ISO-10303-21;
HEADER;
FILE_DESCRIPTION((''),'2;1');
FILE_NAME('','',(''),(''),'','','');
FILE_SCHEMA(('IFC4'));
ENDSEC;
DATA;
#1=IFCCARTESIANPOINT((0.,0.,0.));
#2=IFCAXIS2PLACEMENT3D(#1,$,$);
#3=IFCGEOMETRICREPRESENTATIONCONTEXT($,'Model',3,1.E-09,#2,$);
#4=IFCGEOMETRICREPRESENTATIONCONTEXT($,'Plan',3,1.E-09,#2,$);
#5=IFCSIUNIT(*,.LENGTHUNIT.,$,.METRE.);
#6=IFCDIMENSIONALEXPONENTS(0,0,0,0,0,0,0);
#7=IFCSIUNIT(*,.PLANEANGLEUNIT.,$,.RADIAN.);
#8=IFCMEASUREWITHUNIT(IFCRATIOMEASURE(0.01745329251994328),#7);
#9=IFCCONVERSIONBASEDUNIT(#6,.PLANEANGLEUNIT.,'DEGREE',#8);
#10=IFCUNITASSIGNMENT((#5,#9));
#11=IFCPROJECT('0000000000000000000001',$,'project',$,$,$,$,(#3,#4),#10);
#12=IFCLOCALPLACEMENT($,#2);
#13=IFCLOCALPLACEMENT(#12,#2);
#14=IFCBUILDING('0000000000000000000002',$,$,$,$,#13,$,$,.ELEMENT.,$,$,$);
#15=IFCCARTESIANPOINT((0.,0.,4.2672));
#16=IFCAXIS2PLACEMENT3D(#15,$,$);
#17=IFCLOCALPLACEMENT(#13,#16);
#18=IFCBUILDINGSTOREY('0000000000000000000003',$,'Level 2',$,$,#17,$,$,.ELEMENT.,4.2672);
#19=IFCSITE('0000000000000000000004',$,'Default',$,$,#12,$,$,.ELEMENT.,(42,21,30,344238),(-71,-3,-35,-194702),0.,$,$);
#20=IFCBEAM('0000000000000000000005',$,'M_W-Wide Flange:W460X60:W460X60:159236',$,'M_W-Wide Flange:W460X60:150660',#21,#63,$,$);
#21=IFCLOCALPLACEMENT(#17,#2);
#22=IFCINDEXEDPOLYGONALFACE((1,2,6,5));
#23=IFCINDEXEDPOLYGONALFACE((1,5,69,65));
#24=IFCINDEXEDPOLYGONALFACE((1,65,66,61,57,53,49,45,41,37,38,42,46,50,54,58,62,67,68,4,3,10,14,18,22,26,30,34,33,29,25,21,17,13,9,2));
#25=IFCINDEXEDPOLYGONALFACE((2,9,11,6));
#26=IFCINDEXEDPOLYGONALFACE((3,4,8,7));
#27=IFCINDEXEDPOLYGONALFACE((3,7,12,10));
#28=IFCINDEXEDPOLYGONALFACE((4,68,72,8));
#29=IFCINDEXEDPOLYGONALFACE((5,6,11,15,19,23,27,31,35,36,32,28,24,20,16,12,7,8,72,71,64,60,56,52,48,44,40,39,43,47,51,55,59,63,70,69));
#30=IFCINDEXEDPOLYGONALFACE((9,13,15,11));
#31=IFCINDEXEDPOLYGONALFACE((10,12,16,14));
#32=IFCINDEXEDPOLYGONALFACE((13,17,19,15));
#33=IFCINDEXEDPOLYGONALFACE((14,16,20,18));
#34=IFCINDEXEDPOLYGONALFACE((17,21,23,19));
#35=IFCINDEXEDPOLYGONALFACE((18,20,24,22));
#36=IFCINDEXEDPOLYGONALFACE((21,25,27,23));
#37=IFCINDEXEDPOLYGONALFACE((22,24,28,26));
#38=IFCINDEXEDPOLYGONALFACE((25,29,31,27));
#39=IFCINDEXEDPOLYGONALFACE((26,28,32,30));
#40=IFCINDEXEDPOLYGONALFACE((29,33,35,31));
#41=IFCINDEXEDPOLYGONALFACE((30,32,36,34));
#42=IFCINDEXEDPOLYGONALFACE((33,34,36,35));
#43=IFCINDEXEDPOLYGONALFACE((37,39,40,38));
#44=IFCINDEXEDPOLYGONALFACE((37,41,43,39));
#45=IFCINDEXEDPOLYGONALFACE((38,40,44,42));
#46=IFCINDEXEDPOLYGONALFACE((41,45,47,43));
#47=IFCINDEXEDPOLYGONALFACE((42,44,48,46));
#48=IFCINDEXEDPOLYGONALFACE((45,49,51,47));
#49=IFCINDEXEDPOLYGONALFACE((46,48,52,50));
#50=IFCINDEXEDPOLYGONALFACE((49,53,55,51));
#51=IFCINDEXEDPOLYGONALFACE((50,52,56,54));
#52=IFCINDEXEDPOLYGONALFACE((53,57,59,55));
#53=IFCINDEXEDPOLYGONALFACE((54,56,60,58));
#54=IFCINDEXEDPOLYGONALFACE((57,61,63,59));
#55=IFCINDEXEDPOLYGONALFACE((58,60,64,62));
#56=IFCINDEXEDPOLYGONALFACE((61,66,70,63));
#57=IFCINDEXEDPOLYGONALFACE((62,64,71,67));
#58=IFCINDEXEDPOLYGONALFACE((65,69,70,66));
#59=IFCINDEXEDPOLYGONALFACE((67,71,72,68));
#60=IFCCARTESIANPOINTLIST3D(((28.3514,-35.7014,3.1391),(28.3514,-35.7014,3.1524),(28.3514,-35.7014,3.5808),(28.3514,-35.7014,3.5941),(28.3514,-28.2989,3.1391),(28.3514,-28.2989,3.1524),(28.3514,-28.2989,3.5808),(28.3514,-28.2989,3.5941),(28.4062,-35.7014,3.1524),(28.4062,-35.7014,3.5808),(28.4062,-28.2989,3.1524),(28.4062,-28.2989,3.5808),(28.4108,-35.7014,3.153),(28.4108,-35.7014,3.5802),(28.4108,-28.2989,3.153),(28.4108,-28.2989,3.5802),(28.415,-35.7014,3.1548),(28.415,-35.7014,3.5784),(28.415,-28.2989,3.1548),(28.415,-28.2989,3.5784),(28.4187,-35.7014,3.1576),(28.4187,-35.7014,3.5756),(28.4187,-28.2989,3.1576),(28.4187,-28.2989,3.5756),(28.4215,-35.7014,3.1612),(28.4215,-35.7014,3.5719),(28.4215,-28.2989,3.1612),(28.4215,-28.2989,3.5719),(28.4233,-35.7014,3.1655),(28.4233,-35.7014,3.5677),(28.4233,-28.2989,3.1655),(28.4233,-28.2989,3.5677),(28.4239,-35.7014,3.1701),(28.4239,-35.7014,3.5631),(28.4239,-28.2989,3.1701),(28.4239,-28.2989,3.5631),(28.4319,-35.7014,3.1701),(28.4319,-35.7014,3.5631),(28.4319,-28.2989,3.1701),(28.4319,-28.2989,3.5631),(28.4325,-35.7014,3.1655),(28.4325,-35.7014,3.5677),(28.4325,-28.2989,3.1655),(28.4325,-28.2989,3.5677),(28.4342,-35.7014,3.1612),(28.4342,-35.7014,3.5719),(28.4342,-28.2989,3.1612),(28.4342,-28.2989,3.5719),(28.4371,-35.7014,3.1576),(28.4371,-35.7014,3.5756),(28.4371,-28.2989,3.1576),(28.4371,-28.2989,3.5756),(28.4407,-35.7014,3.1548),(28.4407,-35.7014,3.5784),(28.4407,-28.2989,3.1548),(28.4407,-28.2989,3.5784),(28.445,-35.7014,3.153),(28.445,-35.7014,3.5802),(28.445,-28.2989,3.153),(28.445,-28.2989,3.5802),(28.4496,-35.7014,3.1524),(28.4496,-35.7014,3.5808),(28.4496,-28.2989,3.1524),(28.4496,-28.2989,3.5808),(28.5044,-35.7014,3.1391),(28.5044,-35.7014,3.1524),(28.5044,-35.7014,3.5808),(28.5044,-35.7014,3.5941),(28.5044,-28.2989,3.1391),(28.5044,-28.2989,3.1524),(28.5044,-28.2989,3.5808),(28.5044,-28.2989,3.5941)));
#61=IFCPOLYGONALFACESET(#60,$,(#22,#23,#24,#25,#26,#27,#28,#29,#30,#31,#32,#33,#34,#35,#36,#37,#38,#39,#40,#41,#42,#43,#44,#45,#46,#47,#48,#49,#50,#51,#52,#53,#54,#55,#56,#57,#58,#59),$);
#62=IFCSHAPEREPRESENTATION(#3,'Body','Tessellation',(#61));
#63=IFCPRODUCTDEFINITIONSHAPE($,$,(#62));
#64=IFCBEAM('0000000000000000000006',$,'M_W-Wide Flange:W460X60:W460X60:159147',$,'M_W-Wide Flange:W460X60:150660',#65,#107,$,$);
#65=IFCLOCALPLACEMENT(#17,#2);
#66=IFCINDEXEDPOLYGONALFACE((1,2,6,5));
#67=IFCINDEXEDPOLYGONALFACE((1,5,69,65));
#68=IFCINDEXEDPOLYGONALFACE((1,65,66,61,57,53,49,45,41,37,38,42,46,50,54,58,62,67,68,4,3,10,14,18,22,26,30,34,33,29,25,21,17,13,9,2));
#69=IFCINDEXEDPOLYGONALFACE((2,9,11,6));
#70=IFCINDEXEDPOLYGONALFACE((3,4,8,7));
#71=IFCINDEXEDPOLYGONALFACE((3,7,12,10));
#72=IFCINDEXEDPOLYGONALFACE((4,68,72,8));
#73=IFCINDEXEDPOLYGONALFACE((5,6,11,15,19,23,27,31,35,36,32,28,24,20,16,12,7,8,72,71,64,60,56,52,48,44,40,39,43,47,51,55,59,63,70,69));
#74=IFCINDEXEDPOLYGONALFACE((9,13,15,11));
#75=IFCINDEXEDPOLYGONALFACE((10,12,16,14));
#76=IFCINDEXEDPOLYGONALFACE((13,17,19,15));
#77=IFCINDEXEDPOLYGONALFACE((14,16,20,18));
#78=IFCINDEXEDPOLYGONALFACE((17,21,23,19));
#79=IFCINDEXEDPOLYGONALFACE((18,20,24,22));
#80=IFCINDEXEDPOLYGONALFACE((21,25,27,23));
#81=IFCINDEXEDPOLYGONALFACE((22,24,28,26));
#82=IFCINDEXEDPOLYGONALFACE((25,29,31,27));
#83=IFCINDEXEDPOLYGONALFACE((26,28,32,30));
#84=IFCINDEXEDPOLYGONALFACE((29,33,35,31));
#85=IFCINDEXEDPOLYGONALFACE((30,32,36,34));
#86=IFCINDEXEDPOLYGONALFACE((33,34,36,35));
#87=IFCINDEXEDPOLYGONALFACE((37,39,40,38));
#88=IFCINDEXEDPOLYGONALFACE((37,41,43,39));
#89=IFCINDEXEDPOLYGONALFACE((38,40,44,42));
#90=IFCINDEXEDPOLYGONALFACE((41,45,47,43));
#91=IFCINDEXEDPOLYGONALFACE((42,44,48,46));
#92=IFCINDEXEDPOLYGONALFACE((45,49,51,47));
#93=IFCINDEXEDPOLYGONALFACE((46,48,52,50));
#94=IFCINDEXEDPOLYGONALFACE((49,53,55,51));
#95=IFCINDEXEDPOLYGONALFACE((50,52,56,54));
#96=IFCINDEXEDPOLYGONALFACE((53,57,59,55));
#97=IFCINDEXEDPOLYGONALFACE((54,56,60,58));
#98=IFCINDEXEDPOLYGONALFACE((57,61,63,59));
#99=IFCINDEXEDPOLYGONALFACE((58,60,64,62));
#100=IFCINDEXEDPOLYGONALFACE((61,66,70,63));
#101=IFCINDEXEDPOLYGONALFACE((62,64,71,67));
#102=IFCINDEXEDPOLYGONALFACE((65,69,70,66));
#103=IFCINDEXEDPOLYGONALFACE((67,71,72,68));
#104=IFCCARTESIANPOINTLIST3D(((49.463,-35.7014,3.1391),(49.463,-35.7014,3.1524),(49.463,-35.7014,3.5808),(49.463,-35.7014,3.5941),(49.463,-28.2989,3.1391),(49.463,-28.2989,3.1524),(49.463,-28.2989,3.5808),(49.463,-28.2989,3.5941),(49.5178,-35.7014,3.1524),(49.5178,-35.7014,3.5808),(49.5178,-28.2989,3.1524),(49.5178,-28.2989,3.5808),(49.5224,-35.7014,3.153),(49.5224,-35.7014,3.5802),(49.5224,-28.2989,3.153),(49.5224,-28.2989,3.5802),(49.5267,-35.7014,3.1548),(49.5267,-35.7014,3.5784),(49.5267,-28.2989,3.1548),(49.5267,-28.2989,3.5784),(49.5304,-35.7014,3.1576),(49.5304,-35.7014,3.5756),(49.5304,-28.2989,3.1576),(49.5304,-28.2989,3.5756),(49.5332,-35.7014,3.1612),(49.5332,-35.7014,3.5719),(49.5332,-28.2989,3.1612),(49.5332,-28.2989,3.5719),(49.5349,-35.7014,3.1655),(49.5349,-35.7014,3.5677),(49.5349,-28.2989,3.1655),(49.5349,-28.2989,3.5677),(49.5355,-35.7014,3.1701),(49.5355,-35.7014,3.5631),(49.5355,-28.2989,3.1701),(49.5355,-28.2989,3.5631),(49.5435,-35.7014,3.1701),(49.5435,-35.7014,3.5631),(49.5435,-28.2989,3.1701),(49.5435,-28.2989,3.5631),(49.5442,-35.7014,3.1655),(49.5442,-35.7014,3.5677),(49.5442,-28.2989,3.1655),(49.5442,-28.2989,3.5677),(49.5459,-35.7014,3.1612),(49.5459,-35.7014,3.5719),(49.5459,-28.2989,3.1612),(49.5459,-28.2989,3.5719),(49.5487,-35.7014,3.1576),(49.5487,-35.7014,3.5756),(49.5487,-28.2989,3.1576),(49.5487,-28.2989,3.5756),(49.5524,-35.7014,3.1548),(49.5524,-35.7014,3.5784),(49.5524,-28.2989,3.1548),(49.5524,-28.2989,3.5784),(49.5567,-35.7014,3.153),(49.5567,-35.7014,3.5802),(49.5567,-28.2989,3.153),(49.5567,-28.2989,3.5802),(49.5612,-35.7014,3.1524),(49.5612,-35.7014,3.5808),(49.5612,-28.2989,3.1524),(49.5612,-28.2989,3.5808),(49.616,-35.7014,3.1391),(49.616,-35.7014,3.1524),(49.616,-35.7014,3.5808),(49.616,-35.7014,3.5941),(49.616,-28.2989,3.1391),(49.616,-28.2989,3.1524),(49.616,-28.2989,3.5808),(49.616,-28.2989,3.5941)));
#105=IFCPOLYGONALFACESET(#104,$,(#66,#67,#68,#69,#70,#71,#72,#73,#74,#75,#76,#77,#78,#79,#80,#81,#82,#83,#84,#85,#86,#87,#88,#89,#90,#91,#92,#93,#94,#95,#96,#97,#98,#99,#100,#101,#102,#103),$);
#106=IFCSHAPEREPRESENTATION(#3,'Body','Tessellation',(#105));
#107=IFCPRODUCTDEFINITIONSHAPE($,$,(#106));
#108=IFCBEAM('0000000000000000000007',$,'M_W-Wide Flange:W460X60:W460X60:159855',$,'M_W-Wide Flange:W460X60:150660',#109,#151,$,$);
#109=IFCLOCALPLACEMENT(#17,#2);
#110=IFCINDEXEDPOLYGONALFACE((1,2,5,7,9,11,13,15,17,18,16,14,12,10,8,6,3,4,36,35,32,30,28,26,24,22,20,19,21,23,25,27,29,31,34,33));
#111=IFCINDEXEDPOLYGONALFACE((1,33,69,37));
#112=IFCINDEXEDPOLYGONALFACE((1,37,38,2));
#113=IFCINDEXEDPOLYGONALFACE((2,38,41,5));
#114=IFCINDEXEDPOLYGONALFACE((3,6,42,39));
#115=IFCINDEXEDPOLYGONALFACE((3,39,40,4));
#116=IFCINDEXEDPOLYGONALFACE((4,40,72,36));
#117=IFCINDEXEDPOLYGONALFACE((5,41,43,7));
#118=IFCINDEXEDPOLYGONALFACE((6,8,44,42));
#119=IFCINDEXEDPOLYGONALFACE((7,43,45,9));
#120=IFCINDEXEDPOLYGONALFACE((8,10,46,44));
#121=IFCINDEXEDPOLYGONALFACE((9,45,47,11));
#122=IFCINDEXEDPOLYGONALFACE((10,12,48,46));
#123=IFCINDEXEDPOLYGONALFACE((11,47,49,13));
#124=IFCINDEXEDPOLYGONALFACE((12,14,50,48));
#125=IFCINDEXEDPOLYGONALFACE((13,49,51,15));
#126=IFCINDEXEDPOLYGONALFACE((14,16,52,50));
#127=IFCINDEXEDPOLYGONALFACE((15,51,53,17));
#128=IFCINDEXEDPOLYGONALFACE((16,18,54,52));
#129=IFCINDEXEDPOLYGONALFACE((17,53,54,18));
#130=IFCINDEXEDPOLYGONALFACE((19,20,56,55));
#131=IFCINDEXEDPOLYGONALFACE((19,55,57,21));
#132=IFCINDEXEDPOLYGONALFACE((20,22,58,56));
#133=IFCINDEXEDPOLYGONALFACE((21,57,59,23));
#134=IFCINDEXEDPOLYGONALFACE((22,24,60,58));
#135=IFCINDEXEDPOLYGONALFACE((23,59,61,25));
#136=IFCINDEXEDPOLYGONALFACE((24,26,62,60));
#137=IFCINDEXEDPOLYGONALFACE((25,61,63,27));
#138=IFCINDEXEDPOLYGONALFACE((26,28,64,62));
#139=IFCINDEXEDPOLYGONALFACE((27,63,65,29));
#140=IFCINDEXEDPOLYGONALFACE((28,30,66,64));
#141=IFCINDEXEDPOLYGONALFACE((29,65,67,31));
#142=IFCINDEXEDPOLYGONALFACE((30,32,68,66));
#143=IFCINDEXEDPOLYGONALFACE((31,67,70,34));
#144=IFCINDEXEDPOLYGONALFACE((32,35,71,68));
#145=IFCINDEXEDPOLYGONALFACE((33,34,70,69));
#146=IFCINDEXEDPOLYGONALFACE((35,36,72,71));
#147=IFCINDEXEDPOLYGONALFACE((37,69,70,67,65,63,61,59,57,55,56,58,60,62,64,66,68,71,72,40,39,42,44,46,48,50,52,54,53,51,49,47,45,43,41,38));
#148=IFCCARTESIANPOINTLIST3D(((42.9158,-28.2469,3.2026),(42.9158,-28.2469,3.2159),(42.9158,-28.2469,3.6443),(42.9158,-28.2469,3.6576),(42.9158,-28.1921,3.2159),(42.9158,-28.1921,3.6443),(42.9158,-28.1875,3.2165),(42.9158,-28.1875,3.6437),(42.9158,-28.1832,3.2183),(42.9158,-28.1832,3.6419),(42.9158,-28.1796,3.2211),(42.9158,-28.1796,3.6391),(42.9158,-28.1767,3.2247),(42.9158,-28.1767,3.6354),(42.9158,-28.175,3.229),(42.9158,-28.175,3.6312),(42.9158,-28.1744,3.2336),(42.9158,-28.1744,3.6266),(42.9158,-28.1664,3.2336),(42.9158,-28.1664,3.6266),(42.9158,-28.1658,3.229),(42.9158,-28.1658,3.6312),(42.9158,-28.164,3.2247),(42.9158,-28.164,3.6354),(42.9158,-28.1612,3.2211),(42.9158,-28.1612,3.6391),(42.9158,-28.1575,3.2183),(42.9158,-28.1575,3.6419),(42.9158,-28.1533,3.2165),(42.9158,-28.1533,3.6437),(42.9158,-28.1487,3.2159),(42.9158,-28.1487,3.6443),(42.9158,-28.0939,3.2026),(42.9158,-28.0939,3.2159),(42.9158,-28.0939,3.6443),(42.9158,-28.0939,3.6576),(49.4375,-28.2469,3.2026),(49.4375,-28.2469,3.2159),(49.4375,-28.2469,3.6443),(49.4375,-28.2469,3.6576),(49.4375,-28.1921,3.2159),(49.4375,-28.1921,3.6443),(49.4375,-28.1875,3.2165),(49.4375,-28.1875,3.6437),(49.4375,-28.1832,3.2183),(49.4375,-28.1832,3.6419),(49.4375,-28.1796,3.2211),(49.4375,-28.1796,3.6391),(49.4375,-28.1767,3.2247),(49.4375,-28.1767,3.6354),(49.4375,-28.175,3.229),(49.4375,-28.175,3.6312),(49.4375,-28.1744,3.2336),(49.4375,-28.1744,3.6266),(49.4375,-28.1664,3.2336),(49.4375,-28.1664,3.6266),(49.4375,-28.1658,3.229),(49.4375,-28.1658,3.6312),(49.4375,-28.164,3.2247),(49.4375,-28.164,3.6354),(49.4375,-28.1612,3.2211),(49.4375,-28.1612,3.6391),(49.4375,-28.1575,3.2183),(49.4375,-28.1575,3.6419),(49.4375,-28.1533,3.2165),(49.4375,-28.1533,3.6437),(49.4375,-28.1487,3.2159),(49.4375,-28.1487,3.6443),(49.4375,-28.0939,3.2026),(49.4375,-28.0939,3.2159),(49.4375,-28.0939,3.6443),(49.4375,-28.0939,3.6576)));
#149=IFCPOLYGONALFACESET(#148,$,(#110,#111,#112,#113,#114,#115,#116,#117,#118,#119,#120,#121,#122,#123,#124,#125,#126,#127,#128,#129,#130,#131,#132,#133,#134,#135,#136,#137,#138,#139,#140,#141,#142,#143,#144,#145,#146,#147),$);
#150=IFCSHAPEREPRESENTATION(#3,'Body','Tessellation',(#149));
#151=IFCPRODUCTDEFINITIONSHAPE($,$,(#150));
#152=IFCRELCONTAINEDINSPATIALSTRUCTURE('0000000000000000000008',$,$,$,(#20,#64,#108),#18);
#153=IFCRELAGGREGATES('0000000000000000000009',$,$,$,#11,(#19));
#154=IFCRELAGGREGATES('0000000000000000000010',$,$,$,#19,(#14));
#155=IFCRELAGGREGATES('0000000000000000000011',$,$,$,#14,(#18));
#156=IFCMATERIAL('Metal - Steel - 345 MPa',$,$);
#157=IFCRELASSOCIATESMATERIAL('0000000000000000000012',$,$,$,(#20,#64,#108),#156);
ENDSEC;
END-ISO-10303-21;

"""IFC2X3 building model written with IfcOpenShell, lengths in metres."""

from ifc_helpers import new_model, entity, si_unit, converted_unit, frame, frame_2d, origin, place, context, project, spatial, polyline, circle_curve, parameter, trimmed, segment, composite_curve, outline, extrude, material, element, save


model = new_model("IFC2X3")

# Units and contexts
model_context = context("Model", 3, precision=1e-09, world=origin())
plan_context = context("Plan", 3, precision=1e-09, world=origin())
ifc_project = project(units=[si_unit("LENGTHUNIT", "METRE"), converted_unit("PLANEANGLEUNIT", "DEGREE", entity("IfcRatioMeasure", 0.01745329251994328), si_unit("PLANEANGLEUNIT", "RADIAN"), dimensions=[0, 0, 0, 0, 0, 0, 0])], contexts=[model_context, plan_context])

# Site, building, storey
site_placement = place(None, origin())
site = spatial("IfcSite", under=ifc_project, at=site_placement, Name="Default", CompositionType="ELEMENT", RefLatitude=(42, 21, 30, 344238), RefLongitude=(-71, -3, -35, -194702), RefElevation=0.0)
building_placement = place(site_placement, origin())
building = spatial("IfcBuilding", under=site, at=building_placement, CompositionType="ELEMENT")
storey_placement = place(building_placement, frame((0.0, 0.0, 4.2672)))
storey = spatial("IfcBuildingStorey", under=building, at=storey_placement, Name="Level 2", CompositionType="ELEMENT", Elevation=4.2672)

# Shared definitions
ifc_material = material(Name="Metal - Steel - 345 MPa")

# Beams
beam_1_placement = place(storey_placement, frame((28.4279, -35.8299, 3.6576)))
element("IfcBeam", 1, at=beam_1_placement, inside=storey, material=ifc_material, Name="M_W-Wide Flange:W460X60:W460X60:159236", ObjectType="M_W-Wide Flange:W460X60:150660", context=model_context, shape_type="SweptSolid", body=[
    extrude(outline(composite_curve([segment(polyline([(-0.0765, -0.2142), (-0.0765, -0.2275)]), True, "CONTINUOUS"), segment(polyline([(-0.0765, -0.2275), (0.0765, -0.2275)]), True, "CONTINUOUS"), segment(polyline([(0.0765, -0.2275), (0.0765, -0.2142)]), True, "CONTINUOUS"), segment(polyline([(0.0765, -0.2142), (0.0217, -0.2142)]), True, "CONTINUOUS"), segment(trimmed(circle_curve(frame_2d((0.0217, -0.1965), x_axis=(0.0, -1.0)), 0.0177), [parameter(270.0)], [parameter(360.0)], True, "PARAMETER"), False, "CONTINUOUS"), segment(polyline([(0.004, -0.1965), (0.004, 0.1965)]), True, "CONTINUOUS"), segment(trimmed(circle_curve(frame_2d((0.0217, 0.1965), x_axis=(-1.0, 0.0)), 0.0177), [parameter(270.0)], [parameter(360.0)], True, "PARAMETER"), False, "CONTINUOUS"), segment(polyline([(0.0217, 0.2142), (0.0765, 0.2142)]), True, "CONTINUOUS"), segment(polyline([(0.0765, 0.2142), (0.0765, 0.2275)]), True, "CONTINUOUS"), segment(polyline([(0.0765, 0.2275), (-0.0765, 0.2275)]), True, "CONTINUOUS"), segment(polyline([(-0.0765, 0.2275), (-0.0765, 0.2142)]), True, "CONTINUOUS"), segment(polyline([(-0.0765, 0.2142), (-0.0217, 0.2142)]), True, "CONTINUOUS"), segment(trimmed(circle_curve(frame_2d((-0.0217, 0.1965), x_axis=(0.0, 1.0)), 0.0177), [parameter(270.0)], [parameter(360.0)], True, "PARAMETER"), False, "CONTINUOUS"), segment(polyline([(-0.004, 0.1965), (-0.004, -0.1965)]), True, "CONTINUOUS"), segment(trimmed(circle_curve(frame_2d((-0.0217, -0.1965), x_axis=(1.0, 0.0)), 0.0177), [parameter(270.0)], [parameter(0.0)], True, "PARAMETER"), False, "CONTINUOUS"), segment(polyline([(-0.0217, -0.2142), (-0.0765, -0.2142)]), True, "CONTINUOUS")], self_intersect=False)), frame((0.0, 0.1285, -0.291), z_axis=(0.0, -1.0, 0.0), x_axis=(1.0, 0.0, 0.0)), (0.0, 0.0, -1.0), 7.4025),
])
beam_2_placement = place(storey_placement, frame((49.5395, -35.8299, 3.6576)))
element("IfcBeam", 2, at=beam_2_placement, inside=storey, material=ifc_material, Name="M_W-Wide Flange:W460X60:W460X60:159147", ObjectType="M_W-Wide Flange:W460X60:150660", context=model_context, shape_type="SweptSolid", body=[
    extrude(outline(composite_curve([segment(polyline([(-0.0765, -0.2142), (-0.0765, -0.2275)]), True, "CONTINUOUS"), segment(polyline([(-0.0765, -0.2275), (0.0765, -0.2275)]), True, "CONTINUOUS"), segment(polyline([(0.0765, -0.2275), (0.0765, -0.2142)]), True, "CONTINUOUS"), segment(polyline([(0.0765, -0.2142), (0.0217, -0.2142)]), True, "CONTINUOUS"), segment(trimmed(circle_curve(frame_2d((0.0217, -0.1965), x_axis=(0.0, -1.0)), 0.0177), [parameter(270.0)], [parameter(360.0)], True, "PARAMETER"), False, "CONTINUOUS"), segment(polyline([(0.004, -0.1965), (0.004, 0.1965)]), True, "CONTINUOUS"), segment(trimmed(circle_curve(frame_2d((0.0217, 0.1965), x_axis=(-1.0, 0.0)), 0.0177), [parameter(270.0)], [parameter(360.0)], True, "PARAMETER"), False, "CONTINUOUS"), segment(polyline([(0.0217, 0.2142), (0.0765, 0.2142)]), True, "CONTINUOUS"), segment(polyline([(0.0765, 0.2142), (0.0765, 0.2275)]), True, "CONTINUOUS"), segment(polyline([(0.0765, 0.2275), (-0.0765, 0.2275)]), True, "CONTINUOUS"), segment(polyline([(-0.0765, 0.2275), (-0.0765, 0.2142)]), True, "CONTINUOUS"), segment(polyline([(-0.0765, 0.2142), (-0.0217, 0.2142)]), True, "CONTINUOUS"), segment(trimmed(circle_curve(frame_2d((-0.0217, 0.1965), x_axis=(0.0, 1.0)), 0.0177), [parameter(270.0)], [parameter(360.0)], True, "PARAMETER"), False, "CONTINUOUS"), segment(polyline([(-0.004, 0.1965), (-0.004, -0.1965)]), True, "CONTINUOUS"), segment(trimmed(circle_curve(frame_2d((-0.0217, -0.1965), x_axis=(1.0, 0.0)), 0.0177), [parameter(270.0)], [parameter(0.0)], True, "PARAMETER"), False, "CONTINUOUS"), segment(polyline([(-0.0217, -0.2142), (-0.0765, -0.2142)]), True, "CONTINUOUS")], self_intersect=False)), frame((0.0, 0.1285, -0.291), z_axis=(0.0, -1.0, 0.0), x_axis=(1.0, 0.0, 0.0)), (0.0, 0.0, -1.0), 7.4025),
])
beam_3_placement = place(storey_placement, frame((49.5395, -28.1704, 3.6576), z_axis=(0.0, 0.0, 1.0), x_axis=(0.0, 1.0, 0.0)))
element("IfcBeam", 3, at=beam_3_placement, inside=storey, material=ifc_material, Name="M_W-Wide Flange:W460X60:W460X60:159855", ObjectType="M_W-Wide Flange:W460X60:150660", context=model_context, shape_type="SweptSolid", body=[
    extrude(outline(composite_curve([segment(polyline([(0.2142, -0.0765), (0.2275, -0.0765)]), True, "CONTINUOUS"), segment(polyline([(0.2275, -0.0765), (0.2275, 0.0765)]), True, "CONTINUOUS"), segment(polyline([(0.2275, 0.0765), (0.2142, 0.0765)]), True, "CONTINUOUS"), segment(polyline([(0.2142, 0.0765), (0.2142, 0.0217)]), True, "CONTINUOUS"), segment(trimmed(circle_curve(frame_2d((0.1965, 0.0217), x_axis=(1.0, 0.0)), 0.0177), [parameter(270.0)], [parameter(360.0)], True, "PARAMETER"), False, "CONTINUOUS"), segment(polyline([(0.1965, 0.004), (-0.1965, 0.004)]), True, "CONTINUOUS"), segment(trimmed(circle_curve(frame_2d((-0.1965, 0.0217), x_axis=(0.0, -1.0)), 0.0177), [parameter(270.0)], [parameter(360.0)], True, "PARAMETER"), False, "CONTINUOUS"), segment(polyline([(-0.2142, 0.0217), (-0.2142, 0.0765)]), True, "CONTINUOUS"), segment(polyline([(-0.2142, 0.0765), (-0.2275, 0.0765)]), True, "CONTINUOUS"), segment(polyline([(-0.2275, 0.0765), (-0.2275, -0.0765)]), True, "CONTINUOUS"), segment(polyline([(-0.2275, -0.0765), (-0.2142, -0.0765)]), True, "CONTINUOUS"), segment(polyline([(-0.2142, -0.0765), (-0.2142, -0.0217)]), True, "CONTINUOUS"), segment(trimmed(circle_curve(frame_2d((-0.1965, -0.0217), x_axis=(-1.0, 0.0)), 0.0177), [parameter(270.0)], [parameter(360.0)], True, "PARAMETER"), False, "CONTINUOUS"), segment(polyline([(-0.1965, -0.004), (0.1965, -0.004)]), True, "CONTINUOUS"), segment(trimmed(circle_curve(frame_2d((0.1965, -0.0217), x_axis=(0.0, 1.0)), 0.0177), [parameter(270.0)], [parameter(0.0)], True, "PARAMETER"), False, "CONTINUOUS"), segment(polyline([(0.2142, -0.0217), (0.2142, -0.0765)]), True, "CONTINUOUS")], self_intersect=False)), frame((0.0, 6.6237, -0.2275), z_axis=(0.0, -1.0, 0.0), x_axis=(0.0, 0.0, -1.0)), (0.0, 0.0, 1.0), 6.5217),
])

save(model, "model.ifc")
